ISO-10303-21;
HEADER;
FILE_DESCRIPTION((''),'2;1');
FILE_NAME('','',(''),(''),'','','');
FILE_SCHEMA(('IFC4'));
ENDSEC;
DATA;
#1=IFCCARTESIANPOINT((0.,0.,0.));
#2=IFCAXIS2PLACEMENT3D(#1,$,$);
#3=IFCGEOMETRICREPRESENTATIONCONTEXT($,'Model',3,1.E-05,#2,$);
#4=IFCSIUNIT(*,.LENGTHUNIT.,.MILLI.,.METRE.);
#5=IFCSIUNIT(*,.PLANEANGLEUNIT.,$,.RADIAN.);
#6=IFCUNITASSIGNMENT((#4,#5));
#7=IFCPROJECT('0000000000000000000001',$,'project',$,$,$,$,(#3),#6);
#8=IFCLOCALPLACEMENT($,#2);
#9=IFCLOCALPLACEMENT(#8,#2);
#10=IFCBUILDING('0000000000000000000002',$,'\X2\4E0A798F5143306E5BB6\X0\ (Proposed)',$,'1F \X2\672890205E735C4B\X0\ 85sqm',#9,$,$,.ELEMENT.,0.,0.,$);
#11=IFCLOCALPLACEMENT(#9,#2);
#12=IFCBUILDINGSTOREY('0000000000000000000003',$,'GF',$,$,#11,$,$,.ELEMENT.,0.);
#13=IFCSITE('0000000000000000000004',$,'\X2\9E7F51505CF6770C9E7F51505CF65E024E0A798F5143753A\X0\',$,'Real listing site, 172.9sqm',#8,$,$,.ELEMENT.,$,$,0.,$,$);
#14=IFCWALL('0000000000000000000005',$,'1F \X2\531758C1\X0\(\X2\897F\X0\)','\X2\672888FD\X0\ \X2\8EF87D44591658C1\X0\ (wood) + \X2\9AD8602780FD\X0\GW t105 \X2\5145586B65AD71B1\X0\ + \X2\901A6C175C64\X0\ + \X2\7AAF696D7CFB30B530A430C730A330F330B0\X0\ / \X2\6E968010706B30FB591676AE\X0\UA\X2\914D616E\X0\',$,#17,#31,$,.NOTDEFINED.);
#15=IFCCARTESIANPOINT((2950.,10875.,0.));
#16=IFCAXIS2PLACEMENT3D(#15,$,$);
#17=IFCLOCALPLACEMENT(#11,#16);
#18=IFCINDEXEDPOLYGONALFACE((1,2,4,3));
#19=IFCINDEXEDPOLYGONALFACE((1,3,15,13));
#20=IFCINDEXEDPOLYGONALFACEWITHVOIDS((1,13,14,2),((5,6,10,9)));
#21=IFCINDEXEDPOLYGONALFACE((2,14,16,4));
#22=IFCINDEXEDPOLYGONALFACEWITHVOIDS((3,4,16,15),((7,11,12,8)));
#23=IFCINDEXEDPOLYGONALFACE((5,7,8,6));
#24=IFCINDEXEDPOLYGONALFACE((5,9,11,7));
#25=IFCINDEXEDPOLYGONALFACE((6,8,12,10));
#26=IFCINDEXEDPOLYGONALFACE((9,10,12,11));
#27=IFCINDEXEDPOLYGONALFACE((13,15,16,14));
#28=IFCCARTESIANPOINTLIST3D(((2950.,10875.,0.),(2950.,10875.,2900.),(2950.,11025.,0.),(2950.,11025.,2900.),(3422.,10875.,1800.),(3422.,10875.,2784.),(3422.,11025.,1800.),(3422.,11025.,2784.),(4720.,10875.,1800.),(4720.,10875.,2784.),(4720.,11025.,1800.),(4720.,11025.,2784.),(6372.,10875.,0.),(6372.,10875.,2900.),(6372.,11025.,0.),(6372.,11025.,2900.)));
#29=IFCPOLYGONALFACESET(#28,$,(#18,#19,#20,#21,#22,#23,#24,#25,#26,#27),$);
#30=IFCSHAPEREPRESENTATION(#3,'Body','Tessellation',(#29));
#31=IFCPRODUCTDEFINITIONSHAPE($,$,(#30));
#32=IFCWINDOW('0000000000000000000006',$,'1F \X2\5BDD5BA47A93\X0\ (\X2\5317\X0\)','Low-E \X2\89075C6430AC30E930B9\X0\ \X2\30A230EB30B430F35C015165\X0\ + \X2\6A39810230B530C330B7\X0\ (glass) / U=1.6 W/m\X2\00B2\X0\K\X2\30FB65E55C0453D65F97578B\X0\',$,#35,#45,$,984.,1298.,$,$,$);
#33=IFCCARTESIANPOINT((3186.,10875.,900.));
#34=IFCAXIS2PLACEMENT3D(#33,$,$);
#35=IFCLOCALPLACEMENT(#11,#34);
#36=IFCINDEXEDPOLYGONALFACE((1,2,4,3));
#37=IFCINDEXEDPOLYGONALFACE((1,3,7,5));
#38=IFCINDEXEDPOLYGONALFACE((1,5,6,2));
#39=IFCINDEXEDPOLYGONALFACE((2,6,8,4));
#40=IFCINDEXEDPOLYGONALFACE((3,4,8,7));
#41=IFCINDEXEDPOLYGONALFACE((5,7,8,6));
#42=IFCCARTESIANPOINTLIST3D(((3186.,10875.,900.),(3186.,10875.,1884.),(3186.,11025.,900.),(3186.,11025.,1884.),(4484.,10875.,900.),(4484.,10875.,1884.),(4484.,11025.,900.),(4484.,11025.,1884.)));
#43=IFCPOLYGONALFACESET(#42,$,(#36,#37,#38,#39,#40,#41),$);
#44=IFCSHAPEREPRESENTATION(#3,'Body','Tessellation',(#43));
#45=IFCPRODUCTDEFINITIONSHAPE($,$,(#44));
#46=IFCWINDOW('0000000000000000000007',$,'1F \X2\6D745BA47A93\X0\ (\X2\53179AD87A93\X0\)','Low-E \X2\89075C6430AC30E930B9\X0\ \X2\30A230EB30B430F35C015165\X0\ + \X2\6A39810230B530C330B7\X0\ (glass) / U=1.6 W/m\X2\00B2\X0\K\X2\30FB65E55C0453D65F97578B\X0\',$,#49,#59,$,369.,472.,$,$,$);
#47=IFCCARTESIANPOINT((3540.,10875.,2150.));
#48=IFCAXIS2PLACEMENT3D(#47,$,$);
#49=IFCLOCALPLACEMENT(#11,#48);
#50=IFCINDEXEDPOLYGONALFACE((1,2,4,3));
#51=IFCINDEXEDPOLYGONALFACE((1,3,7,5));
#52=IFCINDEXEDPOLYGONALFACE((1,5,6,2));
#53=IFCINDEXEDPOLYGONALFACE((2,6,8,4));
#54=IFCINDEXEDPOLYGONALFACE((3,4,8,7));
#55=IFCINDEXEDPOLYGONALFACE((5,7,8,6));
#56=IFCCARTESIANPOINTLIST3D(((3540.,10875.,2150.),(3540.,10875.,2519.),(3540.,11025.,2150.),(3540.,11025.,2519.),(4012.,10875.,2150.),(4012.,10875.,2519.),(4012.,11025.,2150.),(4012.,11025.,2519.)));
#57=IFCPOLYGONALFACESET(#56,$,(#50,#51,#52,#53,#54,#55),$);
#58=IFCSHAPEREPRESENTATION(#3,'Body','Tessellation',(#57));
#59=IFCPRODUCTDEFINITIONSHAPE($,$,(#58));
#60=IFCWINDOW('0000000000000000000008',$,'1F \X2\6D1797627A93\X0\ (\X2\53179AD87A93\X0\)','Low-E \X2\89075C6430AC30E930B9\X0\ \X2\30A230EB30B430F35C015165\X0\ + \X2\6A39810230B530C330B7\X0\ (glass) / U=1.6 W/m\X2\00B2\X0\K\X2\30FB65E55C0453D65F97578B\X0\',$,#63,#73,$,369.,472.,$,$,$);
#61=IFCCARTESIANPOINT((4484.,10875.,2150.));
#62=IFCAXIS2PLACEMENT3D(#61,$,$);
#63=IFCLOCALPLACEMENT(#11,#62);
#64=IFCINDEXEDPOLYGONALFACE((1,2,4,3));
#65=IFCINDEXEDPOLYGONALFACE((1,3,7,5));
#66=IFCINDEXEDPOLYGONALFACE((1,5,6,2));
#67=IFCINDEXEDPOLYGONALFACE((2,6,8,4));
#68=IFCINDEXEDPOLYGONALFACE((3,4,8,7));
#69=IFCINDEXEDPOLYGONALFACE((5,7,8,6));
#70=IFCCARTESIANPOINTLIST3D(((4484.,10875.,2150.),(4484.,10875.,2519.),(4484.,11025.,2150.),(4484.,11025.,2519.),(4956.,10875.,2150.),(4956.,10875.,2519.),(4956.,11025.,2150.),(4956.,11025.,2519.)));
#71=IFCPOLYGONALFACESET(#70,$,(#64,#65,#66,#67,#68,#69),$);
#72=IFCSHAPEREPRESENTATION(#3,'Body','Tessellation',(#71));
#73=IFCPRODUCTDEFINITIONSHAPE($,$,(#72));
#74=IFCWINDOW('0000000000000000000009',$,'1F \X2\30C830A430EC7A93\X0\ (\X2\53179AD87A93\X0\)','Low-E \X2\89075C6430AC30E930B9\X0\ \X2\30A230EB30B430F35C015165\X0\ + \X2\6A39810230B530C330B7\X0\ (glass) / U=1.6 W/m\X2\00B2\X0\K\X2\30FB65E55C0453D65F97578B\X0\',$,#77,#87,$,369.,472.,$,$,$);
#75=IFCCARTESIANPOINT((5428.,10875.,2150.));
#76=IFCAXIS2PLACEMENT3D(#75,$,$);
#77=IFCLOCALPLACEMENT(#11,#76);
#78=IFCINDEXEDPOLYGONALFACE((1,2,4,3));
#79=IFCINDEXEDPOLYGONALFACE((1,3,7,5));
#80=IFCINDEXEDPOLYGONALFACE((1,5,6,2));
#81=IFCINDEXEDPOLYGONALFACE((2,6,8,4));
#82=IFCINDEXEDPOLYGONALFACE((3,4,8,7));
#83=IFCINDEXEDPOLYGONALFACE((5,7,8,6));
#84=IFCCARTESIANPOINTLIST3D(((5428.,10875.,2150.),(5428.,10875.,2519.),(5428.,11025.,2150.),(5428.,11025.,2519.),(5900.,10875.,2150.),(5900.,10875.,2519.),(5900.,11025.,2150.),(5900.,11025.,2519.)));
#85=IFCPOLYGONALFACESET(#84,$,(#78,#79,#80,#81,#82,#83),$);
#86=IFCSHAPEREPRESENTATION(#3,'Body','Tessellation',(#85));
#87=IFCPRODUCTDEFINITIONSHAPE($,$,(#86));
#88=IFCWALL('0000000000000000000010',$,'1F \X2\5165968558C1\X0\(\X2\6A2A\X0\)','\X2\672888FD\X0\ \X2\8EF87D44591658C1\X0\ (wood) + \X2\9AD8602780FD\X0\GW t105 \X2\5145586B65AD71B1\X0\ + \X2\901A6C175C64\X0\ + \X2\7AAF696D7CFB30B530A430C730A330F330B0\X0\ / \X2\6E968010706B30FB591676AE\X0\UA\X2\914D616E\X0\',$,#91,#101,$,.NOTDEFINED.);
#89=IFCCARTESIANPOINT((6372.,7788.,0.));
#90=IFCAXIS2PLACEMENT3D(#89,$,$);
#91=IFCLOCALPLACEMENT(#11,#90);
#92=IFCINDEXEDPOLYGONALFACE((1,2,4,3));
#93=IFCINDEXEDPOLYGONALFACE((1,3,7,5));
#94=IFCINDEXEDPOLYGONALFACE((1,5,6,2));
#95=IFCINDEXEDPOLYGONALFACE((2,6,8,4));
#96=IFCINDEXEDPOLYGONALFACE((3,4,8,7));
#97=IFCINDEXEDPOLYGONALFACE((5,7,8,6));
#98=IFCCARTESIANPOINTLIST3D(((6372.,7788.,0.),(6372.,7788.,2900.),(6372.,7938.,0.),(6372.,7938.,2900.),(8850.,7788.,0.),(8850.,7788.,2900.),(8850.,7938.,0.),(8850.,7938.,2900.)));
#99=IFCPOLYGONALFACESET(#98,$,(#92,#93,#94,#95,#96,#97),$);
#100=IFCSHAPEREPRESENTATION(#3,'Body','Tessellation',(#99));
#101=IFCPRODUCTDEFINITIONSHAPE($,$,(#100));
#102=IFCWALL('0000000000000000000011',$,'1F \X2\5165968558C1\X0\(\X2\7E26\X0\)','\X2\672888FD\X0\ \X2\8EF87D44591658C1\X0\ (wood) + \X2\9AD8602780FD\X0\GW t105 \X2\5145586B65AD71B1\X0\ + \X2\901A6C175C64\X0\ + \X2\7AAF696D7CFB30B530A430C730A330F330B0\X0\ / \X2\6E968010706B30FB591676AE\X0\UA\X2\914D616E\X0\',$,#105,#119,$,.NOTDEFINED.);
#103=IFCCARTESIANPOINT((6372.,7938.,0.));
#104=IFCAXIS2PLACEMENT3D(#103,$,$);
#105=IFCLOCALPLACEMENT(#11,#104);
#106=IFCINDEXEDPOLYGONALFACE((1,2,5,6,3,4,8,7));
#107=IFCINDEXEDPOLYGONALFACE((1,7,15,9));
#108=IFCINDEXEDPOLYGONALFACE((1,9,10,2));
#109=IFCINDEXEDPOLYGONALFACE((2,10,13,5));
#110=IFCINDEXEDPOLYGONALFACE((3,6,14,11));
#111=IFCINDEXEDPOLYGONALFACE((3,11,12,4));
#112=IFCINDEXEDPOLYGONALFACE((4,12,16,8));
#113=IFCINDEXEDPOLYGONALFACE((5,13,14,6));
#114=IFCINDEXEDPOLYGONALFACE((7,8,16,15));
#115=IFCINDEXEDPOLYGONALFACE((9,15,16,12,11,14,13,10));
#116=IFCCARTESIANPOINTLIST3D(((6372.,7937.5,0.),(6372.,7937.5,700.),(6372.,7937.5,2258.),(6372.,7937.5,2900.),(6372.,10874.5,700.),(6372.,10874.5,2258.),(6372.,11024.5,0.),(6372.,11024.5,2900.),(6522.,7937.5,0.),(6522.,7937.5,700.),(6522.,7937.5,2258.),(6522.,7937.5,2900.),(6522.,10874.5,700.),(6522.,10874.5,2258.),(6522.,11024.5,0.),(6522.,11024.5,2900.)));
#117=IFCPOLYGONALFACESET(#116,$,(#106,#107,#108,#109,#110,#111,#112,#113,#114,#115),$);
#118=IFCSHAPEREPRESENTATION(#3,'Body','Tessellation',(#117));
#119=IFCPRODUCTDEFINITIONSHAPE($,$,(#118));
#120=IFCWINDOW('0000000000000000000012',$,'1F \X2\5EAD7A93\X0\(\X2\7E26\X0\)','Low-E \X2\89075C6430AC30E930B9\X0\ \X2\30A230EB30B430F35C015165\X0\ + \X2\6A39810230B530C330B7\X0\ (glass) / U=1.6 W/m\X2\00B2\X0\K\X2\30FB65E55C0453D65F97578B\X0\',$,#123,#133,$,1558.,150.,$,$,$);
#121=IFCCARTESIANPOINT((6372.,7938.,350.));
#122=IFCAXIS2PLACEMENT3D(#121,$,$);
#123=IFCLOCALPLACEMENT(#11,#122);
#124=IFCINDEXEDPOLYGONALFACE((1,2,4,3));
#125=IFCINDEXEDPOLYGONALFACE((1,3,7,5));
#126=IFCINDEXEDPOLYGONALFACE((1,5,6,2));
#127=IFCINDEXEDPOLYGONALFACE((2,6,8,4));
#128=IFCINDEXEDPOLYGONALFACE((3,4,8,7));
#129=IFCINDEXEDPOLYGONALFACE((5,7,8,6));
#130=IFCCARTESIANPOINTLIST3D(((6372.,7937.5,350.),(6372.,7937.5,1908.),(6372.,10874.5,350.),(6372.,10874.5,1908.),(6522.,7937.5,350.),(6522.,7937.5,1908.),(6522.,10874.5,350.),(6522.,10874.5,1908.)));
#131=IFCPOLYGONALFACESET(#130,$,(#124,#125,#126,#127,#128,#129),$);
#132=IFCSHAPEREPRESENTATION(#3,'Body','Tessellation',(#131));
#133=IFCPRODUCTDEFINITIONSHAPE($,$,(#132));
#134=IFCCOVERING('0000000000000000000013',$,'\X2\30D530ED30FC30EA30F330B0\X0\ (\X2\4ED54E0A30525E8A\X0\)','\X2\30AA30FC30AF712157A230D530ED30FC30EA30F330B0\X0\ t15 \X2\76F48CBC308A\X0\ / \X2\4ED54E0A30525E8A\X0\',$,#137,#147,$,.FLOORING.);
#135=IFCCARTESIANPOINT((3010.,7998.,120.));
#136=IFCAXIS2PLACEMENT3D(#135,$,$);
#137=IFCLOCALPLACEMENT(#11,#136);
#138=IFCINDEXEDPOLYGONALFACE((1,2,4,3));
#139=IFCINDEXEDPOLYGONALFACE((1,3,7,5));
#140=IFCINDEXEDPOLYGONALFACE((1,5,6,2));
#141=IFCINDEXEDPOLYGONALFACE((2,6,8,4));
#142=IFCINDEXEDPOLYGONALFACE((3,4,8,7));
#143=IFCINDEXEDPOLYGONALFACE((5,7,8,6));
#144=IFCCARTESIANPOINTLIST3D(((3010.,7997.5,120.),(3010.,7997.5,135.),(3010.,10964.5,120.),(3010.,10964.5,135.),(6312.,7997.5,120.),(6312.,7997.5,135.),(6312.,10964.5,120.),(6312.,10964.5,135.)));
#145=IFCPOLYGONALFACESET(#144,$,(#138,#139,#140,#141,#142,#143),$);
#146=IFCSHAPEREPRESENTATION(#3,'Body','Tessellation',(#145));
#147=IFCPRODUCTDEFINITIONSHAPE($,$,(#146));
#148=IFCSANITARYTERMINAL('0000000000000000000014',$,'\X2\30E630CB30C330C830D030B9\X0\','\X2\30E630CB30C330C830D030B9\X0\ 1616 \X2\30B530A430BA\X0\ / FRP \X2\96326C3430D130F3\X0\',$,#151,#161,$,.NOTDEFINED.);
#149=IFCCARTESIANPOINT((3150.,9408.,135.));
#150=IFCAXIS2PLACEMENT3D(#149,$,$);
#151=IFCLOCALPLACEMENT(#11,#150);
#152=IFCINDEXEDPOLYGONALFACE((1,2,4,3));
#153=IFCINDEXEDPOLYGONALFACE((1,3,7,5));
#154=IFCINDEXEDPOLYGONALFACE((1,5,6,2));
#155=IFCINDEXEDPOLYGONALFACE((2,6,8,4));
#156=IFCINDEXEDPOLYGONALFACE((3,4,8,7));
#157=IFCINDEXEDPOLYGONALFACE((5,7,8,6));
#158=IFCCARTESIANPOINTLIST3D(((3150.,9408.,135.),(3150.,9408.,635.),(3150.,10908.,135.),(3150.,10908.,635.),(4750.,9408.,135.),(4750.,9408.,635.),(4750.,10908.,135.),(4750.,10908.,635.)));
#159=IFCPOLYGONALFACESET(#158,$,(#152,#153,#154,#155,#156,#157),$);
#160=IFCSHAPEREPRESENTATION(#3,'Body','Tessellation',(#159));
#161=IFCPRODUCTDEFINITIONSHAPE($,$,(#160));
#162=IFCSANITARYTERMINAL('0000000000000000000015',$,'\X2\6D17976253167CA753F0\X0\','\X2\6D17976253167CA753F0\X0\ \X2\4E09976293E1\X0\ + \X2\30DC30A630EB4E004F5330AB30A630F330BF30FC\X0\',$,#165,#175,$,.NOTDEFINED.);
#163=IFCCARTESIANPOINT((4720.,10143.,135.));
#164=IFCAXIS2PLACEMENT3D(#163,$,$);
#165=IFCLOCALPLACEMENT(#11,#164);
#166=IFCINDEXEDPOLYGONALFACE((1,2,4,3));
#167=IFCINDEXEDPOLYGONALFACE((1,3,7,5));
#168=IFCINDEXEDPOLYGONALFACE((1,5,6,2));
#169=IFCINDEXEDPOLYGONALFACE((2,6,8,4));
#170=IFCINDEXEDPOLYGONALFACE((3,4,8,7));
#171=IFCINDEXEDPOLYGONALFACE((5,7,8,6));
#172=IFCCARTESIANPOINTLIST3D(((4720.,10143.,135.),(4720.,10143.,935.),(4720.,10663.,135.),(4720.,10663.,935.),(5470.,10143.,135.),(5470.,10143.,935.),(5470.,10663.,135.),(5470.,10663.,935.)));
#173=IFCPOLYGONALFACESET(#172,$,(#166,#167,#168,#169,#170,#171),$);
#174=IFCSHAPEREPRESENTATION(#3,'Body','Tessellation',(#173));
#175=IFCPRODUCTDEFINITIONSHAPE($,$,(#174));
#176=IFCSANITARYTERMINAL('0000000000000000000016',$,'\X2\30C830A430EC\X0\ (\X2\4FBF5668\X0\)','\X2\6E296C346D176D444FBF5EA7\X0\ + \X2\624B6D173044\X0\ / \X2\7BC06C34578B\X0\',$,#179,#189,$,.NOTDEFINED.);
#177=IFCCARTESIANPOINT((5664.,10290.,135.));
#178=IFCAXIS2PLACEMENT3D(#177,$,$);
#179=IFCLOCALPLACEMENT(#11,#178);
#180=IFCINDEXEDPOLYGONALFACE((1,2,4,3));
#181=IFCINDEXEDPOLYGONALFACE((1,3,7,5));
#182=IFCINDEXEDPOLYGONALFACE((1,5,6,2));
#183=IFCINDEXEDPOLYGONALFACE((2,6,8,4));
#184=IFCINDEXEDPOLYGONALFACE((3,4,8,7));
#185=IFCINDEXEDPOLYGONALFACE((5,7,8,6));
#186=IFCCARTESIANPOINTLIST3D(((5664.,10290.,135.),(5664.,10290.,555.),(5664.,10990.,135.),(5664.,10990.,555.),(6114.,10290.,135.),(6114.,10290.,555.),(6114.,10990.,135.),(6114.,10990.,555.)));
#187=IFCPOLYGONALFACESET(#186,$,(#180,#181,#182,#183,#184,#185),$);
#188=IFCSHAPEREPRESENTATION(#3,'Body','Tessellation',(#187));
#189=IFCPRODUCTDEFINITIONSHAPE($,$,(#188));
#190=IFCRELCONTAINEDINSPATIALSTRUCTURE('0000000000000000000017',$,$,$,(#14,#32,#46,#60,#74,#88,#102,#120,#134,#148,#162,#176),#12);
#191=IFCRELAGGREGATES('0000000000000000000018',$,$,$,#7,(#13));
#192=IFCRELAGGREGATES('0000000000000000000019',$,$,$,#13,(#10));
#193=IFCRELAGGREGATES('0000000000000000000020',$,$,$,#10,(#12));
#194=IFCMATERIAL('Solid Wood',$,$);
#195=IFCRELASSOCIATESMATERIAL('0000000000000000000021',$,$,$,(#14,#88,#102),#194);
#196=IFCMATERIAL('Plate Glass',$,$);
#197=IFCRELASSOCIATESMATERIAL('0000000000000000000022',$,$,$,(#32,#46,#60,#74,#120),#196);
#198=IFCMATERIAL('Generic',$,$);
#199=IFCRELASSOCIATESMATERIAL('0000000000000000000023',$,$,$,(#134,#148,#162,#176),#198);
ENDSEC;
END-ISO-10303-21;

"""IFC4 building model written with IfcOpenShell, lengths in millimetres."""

from ifc_helpers import new_model, si_unit, frame, frame_2d, origin, place, context, project, spatial, rectangle, extrude, material, element, fill, save


model = new_model("IFC4")

# Units and contexts
model_context = context("Model", 3, precision=1e-05, world=origin())
ifc_project = project(units=[si_unit("LENGTHUNIT", "METRE", prefix="MILLI"), si_unit("PLANEANGLEUNIT", "RADIAN")], contexts=[model_context])

# Site, building, storey
site_placement = place(None, origin())
site = spatial("IfcSite", under=ifc_project, at=site_placement, Name="鹿児島県鹿児島市上福元町", ObjectType="Real listing site, 172.9sqm", CompositionType="ELEMENT", RefElevation=0.0)
building_placement = place(site_placement, origin())
building = spatial("IfcBuilding", under=site, at=building_placement, Name="上福元の家 (Proposed)", ObjectType="1F 木造平屋 85sqm", CompositionType="ELEMENT", ElevationOfRefHeight=0.0, ElevationOfTerrain=0.0)
storey_placement = place(building_placement, origin())
storey = spatial("IfcBuildingStorey", under=building, at=storey_placement, Name="GF", CompositionType="ELEMENT", Elevation=0.0)

# Shared definitions
ifc_material_1 = material(Name="Solid Wood")

# Wall, openings, windows
wall_1_placement = place(storey_placement, frame((2950.0, 10875.0, 0.0)))
wall_1 = element("IfcWall", 1, at=wall_1_placement, inside=storey, material=ifc_material_1, Name="1F 北壁(西)", Description="木製 軸組外壁 (wood) + 高性能GW t105 充填断熱 + 通気層 + 窯業系サイディング / 準耐火・外皮UA配慮", PredefinedType="NOTDEFINED", context=model_context, shape_type="SweptSolid", body=[
    extrude(rectangle(XDim=3422.0, YDim=150.0, at=frame_2d((1711.0, 75.0))), frame((2950.0, 10875.0, 0.0)), (0.0, 0.0, 1.0), 2900.0),
])
opening_1_placement = place(storey_placement, frame((3186.0, 10875.0, 900.0)))
opening_1 = element("IfcOpeningElement", 2, at=opening_1_placement, cuts=wall_1, PredefinedType="NOTDEFINED", context=model_context, shape_type="SweptSolid", body=[
    extrude(rectangle(XDim=1298.0, YDim=150.0, at=frame_2d((649.0, 75.0))), frame((3186.0, 10875.0, 900.0)), (0.0, 0.0, 1.0), 984.0),
])
opening_2_placement = place(storey_placement, frame((3540.0, 10875.0, 2150.0)))
opening_2 = element("IfcOpeningElement", 3, at=opening_2_placement, cuts=wall_1, PredefinedType="NOTDEFINED", context=model_context, shape_type="SweptSolid", body=[
    extrude(rectangle(XDim=472.0, YDim=150.0, at=frame_2d((236.0, 75.0))), frame((3540.0, 10875.0, 2150.0)), (0.0, 0.0, 1.0), 369.0),
])
opening_3_placement = place(storey_placement, frame((4484.0, 10875.0, 2150.0)))
opening_3 = element("IfcOpeningElement", 4, at=opening_3_placement, cuts=wall_1, PredefinedType="NOTDEFINED", context=model_context, shape_type="SweptSolid", body=[
    extrude(rectangle(XDim=472.0, YDim=150.0, at=frame_2d((236.0, 75.0))), frame((4484.0, 10875.0, 2150.0)), (0.0, 0.0, 1.0), 369.0),
])
opening_4_placement = place(storey_placement, frame((5428.0, 10875.0, 2150.0)))
opening_4 = element("IfcOpeningElement", 5, at=opening_4_placement, cuts=wall_1, PredefinedType="NOTDEFINED", context=model_context, shape_type="SweptSolid", body=[
    extrude(rectangle(XDim=472.0, YDim=150.0, at=frame_2d((236.0, 75.0))), frame((5428.0, 10875.0, 2150.0)), (0.0, 0.0, 1.0), 369.0),
])
ifc_material_2 = material(Name="Plate Glass")
window_1_placement = place(storey_placement, frame((3186.0, 10875.0, 900.0)))
window_1 = element("IfcWindow", 6, at=window_1_placement, inside=storey, material=ifc_material_2, Name="1F 寝室窓 (北)", Description="Low-E 複層ガラス アルゴン封入 + 樹脂サッシ (glass) / U=1.6 W/m²K・日射取得型", OverallHeight=984.0, OverallWidth=1298.0, context=model_context, shape_type="SweptSolid", body=[
    extrude(rectangle(XDim=1298.0, YDim=150.0, at=frame_2d((649.0, 75.0))), frame((3186.0, 10875.0, 900.0)), (0.0, 0.0, 1.0), 984.0),
])
fill(opening_1, window_1)
window_2_placement = place(storey_placement, frame((3540.0, 10875.0, 2150.0)))
window_2 = element("IfcWindow", 7, at=window_2_placement, inside=storey, material=ifc_material_2, Name="1F 浴室窓 (北高窓)", Description="Low-E 複層ガラス アルゴン封入 + 樹脂サッシ (glass) / U=1.6 W/m²K・日射取得型", OverallHeight=369.0, OverallWidth=472.0, context=model_context, shape_type="SweptSolid", body=[
    extrude(rectangle(XDim=472.0, YDim=150.0, at=frame_2d((236.0, 75.0))), frame((3540.0, 10875.0, 2150.0)), (0.0, 0.0, 1.0), 369.0),
])
fill(opening_2, window_2)
window_3_placement = place(storey_placement, frame((4484.0, 10875.0, 2150.0)))
window_3 = element("IfcWindow", 8, at=window_3_placement, inside=storey, material=ifc_material_2, Name="1F 洗面窓 (北高窓)", Description="Low-E 複層ガラス アルゴン封入 + 樹脂サッシ (glass) / U=1.6 W/m²K・日射取得型", OverallHeight=369.0, OverallWidth=472.0, context=model_context, shape_type="SweptSolid", body=[
    extrude(rectangle(XDim=472.0, YDim=150.0, at=frame_2d((236.0, 75.0))), frame((4484.0, 10875.0, 2150.0)), (0.0, 0.0, 1.0), 369.0),
])
fill(opening_3, window_3)
window_4_placement = place(storey_placement, frame((5428.0, 10875.0, 2150.0)))
window_4 = element("IfcWindow", 9, at=window_4_placement, inside=storey, material=ifc_material_2, Name="1F トイレ窓 (北高窓)", Description="Low-E 複層ガラス アルゴン封入 + 樹脂サッシ (glass) / U=1.6 W/m²K・日射取得型", OverallHeight=369.0, OverallWidth=472.0, context=model_context, shape_type="SweptSolid", body=[
    extrude(rectangle(XDim=472.0, YDim=150.0, at=frame_2d((236.0, 75.0))), frame((5428.0, 10875.0, 2150.0)), (0.0, 0.0, 1.0), 369.0),
])
fill(opening_4, window_4)

# Wall
wall_2_placement = place(storey_placement, frame((6372.0, 7788.0, 0.0)))
element("IfcWall", 10, at=wall_2_placement, inside=storey, material=ifc_material_1, Name="1F 入隅壁(横)", Description="木製 軸組外壁 (wood) + 高性能GW t105 充填断熱 + 通気層 + 窯業系サイディング / 準耐火・外皮UA配慮", PredefinedType="NOTDEFINED", context=model_context, shape_type="SweptSolid", body=[
    extrude(rectangle(XDim=2478.0, YDim=150.0, at=frame_2d((1239.0, 75.0))), frame((6372.0, 7788.0, 0.0)), (0.0, 0.0, 1.0), 2900.0),
])

# Wall, opening, window
wall_3_placement = place(storey_placement, frame((6372.0, 7938.0, 0.0)))
wall_3 = element("IfcWall", 11, at=wall_3_placement, inside=storey, material=ifc_material_1, Name="1F 入隅壁(縦)", Description="木製 軸組外壁 (wood) + 高性能GW t105 充填断熱 + 通気層 + 窯業系サイディング / 準耐火・外皮UA配慮", PredefinedType="NOTDEFINED", context=model_context, shape_type="SweptSolid", body=[
    extrude(rectangle(XDim=150.0, YDim=3087.0, at=frame_2d((75.0, 1543.0))), frame((6372.0, 7938.0, 0.0)), (0.0, 0.0, 1.0), 2900.0),
])
opening_5_placement = place(storey_placement, frame((6372.0, 7938.0, 350.0)))
opening_5 = element("IfcOpeningElement", 12, at=opening_5_placement, cuts=wall_3, PredefinedType="NOTDEFINED", context=model_context, shape_type="SweptSolid", body=[
    extrude(rectangle(XDim=150.0, YDim=2937.0, at=frame_2d((75.0, 1468.0))), frame((6372.0, 7938.0, 350.0)), (0.0, 0.0, 1.0), 1558.0),
])
window_5_placement = place(storey_placement, frame((6372.0, 7938.0, 350.0)))
window_5 = element("IfcWindow", 13, at=window_5_placement, inside=storey, material=ifc_material_2, Name="1F 庭窓(縦)", Description="Low-E 複層ガラス アルゴン封入 + 樹脂サッシ (glass) / U=1.6 W/m²K・日射取得型", OverallHeight=1558.0, OverallWidth=150.0, context=model_context, shape_type="SweptSolid", body=[
    extrude(rectangle(XDim=150.0, YDim=2937.0, at=frame_2d((75.0, 1468.0))), frame((6372.0, 7938.0, 350.0)), (0.0, 0.0, 1.0), 1558.0),
])
fill(opening_5, window_5)

# Covering
ifc_material_3 = material(Name="Generic")
covering_placement = place(storey_placement, frame((3010.0, 7998.0, 120.0)))
element("IfcCovering", 14, at=covering_placement, inside=storey, material=ifc_material_3, Name="フローリング (仕上げ床)", Description="オーク無垢フローリング t15 直貼り / 仕上げ床", PredefinedType="FLOORING", context=model_context, shape_type="SweptSolid", body=[
    extrude(rectangle(XDim=3302.0, YDim=2967.0, at=frame_2d((1651.0, 1483.0))), frame((3010.0, 7998.0, 120.0)), (0.0, 0.0, 1.0), 15.0),
])

# Sanitary terminals
sanitary_terminal_1_placement = place(storey_placement, frame((3150.0, 9408.0, 135.0)))
element("IfcSanitaryTerminal", 15, at=sanitary_terminal_1_placement, inside=storey, material=ifc_material_3, Name="ユニットバス", Description="ユニットバス 1616 サイズ / FRP 防水パン", PredefinedType="NOTDEFINED", context=model_context, shape_type="SweptSolid", body=[
    extrude(rectangle(XDim=1600.0, YDim=1500.0, at=frame_2d((800.0, 750.0))), frame((3150.0, 9408.0, 135.0)), (0.0, 0.0, 1.0), 500.0),
])
sanitary_terminal_2_placement = place(storey_placement, frame((4720.0, 10143.0, 135.0)))
element("IfcSanitaryTerminal", 16, at=sanitary_terminal_2_placement, inside=storey, material=ifc_material_3, Name="洗面化粧台", Description="洗面化粧台 三面鏡 + ボウル一体カウンター", PredefinedType="NOTDEFINED", context=model_context, shape_type="SweptSolid", body=[
    extrude(rectangle(XDim=750.0, YDim=520.0, at=frame_2d((375.0, 260.0))), frame((4720.0, 10143.0, 135.0)), (0.0, 0.0, 1.0), 800.0),
])
sanitary_terminal_3_placement = place(storey_placement, frame((5664.0, 10290.0, 135.0)))
element("IfcSanitaryTerminal", 17, at=sanitary_terminal_3_placement, inside=storey, material=ifc_material_3, Name="トイレ (便器)", Description="温水洗浄便座 + 手洗い / 節水型", PredefinedType="NOTDEFINED", context=model_context, shape_type="SweptSolid", body=[
    extrude(rectangle(XDim=450.0, YDim=700.0, at=frame_2d((225.0, 350.0))), frame((5664.0, 10290.0, 135.0)), (0.0, 0.0, 1.0), 420.0),
])

save(model, "model.ifc")
